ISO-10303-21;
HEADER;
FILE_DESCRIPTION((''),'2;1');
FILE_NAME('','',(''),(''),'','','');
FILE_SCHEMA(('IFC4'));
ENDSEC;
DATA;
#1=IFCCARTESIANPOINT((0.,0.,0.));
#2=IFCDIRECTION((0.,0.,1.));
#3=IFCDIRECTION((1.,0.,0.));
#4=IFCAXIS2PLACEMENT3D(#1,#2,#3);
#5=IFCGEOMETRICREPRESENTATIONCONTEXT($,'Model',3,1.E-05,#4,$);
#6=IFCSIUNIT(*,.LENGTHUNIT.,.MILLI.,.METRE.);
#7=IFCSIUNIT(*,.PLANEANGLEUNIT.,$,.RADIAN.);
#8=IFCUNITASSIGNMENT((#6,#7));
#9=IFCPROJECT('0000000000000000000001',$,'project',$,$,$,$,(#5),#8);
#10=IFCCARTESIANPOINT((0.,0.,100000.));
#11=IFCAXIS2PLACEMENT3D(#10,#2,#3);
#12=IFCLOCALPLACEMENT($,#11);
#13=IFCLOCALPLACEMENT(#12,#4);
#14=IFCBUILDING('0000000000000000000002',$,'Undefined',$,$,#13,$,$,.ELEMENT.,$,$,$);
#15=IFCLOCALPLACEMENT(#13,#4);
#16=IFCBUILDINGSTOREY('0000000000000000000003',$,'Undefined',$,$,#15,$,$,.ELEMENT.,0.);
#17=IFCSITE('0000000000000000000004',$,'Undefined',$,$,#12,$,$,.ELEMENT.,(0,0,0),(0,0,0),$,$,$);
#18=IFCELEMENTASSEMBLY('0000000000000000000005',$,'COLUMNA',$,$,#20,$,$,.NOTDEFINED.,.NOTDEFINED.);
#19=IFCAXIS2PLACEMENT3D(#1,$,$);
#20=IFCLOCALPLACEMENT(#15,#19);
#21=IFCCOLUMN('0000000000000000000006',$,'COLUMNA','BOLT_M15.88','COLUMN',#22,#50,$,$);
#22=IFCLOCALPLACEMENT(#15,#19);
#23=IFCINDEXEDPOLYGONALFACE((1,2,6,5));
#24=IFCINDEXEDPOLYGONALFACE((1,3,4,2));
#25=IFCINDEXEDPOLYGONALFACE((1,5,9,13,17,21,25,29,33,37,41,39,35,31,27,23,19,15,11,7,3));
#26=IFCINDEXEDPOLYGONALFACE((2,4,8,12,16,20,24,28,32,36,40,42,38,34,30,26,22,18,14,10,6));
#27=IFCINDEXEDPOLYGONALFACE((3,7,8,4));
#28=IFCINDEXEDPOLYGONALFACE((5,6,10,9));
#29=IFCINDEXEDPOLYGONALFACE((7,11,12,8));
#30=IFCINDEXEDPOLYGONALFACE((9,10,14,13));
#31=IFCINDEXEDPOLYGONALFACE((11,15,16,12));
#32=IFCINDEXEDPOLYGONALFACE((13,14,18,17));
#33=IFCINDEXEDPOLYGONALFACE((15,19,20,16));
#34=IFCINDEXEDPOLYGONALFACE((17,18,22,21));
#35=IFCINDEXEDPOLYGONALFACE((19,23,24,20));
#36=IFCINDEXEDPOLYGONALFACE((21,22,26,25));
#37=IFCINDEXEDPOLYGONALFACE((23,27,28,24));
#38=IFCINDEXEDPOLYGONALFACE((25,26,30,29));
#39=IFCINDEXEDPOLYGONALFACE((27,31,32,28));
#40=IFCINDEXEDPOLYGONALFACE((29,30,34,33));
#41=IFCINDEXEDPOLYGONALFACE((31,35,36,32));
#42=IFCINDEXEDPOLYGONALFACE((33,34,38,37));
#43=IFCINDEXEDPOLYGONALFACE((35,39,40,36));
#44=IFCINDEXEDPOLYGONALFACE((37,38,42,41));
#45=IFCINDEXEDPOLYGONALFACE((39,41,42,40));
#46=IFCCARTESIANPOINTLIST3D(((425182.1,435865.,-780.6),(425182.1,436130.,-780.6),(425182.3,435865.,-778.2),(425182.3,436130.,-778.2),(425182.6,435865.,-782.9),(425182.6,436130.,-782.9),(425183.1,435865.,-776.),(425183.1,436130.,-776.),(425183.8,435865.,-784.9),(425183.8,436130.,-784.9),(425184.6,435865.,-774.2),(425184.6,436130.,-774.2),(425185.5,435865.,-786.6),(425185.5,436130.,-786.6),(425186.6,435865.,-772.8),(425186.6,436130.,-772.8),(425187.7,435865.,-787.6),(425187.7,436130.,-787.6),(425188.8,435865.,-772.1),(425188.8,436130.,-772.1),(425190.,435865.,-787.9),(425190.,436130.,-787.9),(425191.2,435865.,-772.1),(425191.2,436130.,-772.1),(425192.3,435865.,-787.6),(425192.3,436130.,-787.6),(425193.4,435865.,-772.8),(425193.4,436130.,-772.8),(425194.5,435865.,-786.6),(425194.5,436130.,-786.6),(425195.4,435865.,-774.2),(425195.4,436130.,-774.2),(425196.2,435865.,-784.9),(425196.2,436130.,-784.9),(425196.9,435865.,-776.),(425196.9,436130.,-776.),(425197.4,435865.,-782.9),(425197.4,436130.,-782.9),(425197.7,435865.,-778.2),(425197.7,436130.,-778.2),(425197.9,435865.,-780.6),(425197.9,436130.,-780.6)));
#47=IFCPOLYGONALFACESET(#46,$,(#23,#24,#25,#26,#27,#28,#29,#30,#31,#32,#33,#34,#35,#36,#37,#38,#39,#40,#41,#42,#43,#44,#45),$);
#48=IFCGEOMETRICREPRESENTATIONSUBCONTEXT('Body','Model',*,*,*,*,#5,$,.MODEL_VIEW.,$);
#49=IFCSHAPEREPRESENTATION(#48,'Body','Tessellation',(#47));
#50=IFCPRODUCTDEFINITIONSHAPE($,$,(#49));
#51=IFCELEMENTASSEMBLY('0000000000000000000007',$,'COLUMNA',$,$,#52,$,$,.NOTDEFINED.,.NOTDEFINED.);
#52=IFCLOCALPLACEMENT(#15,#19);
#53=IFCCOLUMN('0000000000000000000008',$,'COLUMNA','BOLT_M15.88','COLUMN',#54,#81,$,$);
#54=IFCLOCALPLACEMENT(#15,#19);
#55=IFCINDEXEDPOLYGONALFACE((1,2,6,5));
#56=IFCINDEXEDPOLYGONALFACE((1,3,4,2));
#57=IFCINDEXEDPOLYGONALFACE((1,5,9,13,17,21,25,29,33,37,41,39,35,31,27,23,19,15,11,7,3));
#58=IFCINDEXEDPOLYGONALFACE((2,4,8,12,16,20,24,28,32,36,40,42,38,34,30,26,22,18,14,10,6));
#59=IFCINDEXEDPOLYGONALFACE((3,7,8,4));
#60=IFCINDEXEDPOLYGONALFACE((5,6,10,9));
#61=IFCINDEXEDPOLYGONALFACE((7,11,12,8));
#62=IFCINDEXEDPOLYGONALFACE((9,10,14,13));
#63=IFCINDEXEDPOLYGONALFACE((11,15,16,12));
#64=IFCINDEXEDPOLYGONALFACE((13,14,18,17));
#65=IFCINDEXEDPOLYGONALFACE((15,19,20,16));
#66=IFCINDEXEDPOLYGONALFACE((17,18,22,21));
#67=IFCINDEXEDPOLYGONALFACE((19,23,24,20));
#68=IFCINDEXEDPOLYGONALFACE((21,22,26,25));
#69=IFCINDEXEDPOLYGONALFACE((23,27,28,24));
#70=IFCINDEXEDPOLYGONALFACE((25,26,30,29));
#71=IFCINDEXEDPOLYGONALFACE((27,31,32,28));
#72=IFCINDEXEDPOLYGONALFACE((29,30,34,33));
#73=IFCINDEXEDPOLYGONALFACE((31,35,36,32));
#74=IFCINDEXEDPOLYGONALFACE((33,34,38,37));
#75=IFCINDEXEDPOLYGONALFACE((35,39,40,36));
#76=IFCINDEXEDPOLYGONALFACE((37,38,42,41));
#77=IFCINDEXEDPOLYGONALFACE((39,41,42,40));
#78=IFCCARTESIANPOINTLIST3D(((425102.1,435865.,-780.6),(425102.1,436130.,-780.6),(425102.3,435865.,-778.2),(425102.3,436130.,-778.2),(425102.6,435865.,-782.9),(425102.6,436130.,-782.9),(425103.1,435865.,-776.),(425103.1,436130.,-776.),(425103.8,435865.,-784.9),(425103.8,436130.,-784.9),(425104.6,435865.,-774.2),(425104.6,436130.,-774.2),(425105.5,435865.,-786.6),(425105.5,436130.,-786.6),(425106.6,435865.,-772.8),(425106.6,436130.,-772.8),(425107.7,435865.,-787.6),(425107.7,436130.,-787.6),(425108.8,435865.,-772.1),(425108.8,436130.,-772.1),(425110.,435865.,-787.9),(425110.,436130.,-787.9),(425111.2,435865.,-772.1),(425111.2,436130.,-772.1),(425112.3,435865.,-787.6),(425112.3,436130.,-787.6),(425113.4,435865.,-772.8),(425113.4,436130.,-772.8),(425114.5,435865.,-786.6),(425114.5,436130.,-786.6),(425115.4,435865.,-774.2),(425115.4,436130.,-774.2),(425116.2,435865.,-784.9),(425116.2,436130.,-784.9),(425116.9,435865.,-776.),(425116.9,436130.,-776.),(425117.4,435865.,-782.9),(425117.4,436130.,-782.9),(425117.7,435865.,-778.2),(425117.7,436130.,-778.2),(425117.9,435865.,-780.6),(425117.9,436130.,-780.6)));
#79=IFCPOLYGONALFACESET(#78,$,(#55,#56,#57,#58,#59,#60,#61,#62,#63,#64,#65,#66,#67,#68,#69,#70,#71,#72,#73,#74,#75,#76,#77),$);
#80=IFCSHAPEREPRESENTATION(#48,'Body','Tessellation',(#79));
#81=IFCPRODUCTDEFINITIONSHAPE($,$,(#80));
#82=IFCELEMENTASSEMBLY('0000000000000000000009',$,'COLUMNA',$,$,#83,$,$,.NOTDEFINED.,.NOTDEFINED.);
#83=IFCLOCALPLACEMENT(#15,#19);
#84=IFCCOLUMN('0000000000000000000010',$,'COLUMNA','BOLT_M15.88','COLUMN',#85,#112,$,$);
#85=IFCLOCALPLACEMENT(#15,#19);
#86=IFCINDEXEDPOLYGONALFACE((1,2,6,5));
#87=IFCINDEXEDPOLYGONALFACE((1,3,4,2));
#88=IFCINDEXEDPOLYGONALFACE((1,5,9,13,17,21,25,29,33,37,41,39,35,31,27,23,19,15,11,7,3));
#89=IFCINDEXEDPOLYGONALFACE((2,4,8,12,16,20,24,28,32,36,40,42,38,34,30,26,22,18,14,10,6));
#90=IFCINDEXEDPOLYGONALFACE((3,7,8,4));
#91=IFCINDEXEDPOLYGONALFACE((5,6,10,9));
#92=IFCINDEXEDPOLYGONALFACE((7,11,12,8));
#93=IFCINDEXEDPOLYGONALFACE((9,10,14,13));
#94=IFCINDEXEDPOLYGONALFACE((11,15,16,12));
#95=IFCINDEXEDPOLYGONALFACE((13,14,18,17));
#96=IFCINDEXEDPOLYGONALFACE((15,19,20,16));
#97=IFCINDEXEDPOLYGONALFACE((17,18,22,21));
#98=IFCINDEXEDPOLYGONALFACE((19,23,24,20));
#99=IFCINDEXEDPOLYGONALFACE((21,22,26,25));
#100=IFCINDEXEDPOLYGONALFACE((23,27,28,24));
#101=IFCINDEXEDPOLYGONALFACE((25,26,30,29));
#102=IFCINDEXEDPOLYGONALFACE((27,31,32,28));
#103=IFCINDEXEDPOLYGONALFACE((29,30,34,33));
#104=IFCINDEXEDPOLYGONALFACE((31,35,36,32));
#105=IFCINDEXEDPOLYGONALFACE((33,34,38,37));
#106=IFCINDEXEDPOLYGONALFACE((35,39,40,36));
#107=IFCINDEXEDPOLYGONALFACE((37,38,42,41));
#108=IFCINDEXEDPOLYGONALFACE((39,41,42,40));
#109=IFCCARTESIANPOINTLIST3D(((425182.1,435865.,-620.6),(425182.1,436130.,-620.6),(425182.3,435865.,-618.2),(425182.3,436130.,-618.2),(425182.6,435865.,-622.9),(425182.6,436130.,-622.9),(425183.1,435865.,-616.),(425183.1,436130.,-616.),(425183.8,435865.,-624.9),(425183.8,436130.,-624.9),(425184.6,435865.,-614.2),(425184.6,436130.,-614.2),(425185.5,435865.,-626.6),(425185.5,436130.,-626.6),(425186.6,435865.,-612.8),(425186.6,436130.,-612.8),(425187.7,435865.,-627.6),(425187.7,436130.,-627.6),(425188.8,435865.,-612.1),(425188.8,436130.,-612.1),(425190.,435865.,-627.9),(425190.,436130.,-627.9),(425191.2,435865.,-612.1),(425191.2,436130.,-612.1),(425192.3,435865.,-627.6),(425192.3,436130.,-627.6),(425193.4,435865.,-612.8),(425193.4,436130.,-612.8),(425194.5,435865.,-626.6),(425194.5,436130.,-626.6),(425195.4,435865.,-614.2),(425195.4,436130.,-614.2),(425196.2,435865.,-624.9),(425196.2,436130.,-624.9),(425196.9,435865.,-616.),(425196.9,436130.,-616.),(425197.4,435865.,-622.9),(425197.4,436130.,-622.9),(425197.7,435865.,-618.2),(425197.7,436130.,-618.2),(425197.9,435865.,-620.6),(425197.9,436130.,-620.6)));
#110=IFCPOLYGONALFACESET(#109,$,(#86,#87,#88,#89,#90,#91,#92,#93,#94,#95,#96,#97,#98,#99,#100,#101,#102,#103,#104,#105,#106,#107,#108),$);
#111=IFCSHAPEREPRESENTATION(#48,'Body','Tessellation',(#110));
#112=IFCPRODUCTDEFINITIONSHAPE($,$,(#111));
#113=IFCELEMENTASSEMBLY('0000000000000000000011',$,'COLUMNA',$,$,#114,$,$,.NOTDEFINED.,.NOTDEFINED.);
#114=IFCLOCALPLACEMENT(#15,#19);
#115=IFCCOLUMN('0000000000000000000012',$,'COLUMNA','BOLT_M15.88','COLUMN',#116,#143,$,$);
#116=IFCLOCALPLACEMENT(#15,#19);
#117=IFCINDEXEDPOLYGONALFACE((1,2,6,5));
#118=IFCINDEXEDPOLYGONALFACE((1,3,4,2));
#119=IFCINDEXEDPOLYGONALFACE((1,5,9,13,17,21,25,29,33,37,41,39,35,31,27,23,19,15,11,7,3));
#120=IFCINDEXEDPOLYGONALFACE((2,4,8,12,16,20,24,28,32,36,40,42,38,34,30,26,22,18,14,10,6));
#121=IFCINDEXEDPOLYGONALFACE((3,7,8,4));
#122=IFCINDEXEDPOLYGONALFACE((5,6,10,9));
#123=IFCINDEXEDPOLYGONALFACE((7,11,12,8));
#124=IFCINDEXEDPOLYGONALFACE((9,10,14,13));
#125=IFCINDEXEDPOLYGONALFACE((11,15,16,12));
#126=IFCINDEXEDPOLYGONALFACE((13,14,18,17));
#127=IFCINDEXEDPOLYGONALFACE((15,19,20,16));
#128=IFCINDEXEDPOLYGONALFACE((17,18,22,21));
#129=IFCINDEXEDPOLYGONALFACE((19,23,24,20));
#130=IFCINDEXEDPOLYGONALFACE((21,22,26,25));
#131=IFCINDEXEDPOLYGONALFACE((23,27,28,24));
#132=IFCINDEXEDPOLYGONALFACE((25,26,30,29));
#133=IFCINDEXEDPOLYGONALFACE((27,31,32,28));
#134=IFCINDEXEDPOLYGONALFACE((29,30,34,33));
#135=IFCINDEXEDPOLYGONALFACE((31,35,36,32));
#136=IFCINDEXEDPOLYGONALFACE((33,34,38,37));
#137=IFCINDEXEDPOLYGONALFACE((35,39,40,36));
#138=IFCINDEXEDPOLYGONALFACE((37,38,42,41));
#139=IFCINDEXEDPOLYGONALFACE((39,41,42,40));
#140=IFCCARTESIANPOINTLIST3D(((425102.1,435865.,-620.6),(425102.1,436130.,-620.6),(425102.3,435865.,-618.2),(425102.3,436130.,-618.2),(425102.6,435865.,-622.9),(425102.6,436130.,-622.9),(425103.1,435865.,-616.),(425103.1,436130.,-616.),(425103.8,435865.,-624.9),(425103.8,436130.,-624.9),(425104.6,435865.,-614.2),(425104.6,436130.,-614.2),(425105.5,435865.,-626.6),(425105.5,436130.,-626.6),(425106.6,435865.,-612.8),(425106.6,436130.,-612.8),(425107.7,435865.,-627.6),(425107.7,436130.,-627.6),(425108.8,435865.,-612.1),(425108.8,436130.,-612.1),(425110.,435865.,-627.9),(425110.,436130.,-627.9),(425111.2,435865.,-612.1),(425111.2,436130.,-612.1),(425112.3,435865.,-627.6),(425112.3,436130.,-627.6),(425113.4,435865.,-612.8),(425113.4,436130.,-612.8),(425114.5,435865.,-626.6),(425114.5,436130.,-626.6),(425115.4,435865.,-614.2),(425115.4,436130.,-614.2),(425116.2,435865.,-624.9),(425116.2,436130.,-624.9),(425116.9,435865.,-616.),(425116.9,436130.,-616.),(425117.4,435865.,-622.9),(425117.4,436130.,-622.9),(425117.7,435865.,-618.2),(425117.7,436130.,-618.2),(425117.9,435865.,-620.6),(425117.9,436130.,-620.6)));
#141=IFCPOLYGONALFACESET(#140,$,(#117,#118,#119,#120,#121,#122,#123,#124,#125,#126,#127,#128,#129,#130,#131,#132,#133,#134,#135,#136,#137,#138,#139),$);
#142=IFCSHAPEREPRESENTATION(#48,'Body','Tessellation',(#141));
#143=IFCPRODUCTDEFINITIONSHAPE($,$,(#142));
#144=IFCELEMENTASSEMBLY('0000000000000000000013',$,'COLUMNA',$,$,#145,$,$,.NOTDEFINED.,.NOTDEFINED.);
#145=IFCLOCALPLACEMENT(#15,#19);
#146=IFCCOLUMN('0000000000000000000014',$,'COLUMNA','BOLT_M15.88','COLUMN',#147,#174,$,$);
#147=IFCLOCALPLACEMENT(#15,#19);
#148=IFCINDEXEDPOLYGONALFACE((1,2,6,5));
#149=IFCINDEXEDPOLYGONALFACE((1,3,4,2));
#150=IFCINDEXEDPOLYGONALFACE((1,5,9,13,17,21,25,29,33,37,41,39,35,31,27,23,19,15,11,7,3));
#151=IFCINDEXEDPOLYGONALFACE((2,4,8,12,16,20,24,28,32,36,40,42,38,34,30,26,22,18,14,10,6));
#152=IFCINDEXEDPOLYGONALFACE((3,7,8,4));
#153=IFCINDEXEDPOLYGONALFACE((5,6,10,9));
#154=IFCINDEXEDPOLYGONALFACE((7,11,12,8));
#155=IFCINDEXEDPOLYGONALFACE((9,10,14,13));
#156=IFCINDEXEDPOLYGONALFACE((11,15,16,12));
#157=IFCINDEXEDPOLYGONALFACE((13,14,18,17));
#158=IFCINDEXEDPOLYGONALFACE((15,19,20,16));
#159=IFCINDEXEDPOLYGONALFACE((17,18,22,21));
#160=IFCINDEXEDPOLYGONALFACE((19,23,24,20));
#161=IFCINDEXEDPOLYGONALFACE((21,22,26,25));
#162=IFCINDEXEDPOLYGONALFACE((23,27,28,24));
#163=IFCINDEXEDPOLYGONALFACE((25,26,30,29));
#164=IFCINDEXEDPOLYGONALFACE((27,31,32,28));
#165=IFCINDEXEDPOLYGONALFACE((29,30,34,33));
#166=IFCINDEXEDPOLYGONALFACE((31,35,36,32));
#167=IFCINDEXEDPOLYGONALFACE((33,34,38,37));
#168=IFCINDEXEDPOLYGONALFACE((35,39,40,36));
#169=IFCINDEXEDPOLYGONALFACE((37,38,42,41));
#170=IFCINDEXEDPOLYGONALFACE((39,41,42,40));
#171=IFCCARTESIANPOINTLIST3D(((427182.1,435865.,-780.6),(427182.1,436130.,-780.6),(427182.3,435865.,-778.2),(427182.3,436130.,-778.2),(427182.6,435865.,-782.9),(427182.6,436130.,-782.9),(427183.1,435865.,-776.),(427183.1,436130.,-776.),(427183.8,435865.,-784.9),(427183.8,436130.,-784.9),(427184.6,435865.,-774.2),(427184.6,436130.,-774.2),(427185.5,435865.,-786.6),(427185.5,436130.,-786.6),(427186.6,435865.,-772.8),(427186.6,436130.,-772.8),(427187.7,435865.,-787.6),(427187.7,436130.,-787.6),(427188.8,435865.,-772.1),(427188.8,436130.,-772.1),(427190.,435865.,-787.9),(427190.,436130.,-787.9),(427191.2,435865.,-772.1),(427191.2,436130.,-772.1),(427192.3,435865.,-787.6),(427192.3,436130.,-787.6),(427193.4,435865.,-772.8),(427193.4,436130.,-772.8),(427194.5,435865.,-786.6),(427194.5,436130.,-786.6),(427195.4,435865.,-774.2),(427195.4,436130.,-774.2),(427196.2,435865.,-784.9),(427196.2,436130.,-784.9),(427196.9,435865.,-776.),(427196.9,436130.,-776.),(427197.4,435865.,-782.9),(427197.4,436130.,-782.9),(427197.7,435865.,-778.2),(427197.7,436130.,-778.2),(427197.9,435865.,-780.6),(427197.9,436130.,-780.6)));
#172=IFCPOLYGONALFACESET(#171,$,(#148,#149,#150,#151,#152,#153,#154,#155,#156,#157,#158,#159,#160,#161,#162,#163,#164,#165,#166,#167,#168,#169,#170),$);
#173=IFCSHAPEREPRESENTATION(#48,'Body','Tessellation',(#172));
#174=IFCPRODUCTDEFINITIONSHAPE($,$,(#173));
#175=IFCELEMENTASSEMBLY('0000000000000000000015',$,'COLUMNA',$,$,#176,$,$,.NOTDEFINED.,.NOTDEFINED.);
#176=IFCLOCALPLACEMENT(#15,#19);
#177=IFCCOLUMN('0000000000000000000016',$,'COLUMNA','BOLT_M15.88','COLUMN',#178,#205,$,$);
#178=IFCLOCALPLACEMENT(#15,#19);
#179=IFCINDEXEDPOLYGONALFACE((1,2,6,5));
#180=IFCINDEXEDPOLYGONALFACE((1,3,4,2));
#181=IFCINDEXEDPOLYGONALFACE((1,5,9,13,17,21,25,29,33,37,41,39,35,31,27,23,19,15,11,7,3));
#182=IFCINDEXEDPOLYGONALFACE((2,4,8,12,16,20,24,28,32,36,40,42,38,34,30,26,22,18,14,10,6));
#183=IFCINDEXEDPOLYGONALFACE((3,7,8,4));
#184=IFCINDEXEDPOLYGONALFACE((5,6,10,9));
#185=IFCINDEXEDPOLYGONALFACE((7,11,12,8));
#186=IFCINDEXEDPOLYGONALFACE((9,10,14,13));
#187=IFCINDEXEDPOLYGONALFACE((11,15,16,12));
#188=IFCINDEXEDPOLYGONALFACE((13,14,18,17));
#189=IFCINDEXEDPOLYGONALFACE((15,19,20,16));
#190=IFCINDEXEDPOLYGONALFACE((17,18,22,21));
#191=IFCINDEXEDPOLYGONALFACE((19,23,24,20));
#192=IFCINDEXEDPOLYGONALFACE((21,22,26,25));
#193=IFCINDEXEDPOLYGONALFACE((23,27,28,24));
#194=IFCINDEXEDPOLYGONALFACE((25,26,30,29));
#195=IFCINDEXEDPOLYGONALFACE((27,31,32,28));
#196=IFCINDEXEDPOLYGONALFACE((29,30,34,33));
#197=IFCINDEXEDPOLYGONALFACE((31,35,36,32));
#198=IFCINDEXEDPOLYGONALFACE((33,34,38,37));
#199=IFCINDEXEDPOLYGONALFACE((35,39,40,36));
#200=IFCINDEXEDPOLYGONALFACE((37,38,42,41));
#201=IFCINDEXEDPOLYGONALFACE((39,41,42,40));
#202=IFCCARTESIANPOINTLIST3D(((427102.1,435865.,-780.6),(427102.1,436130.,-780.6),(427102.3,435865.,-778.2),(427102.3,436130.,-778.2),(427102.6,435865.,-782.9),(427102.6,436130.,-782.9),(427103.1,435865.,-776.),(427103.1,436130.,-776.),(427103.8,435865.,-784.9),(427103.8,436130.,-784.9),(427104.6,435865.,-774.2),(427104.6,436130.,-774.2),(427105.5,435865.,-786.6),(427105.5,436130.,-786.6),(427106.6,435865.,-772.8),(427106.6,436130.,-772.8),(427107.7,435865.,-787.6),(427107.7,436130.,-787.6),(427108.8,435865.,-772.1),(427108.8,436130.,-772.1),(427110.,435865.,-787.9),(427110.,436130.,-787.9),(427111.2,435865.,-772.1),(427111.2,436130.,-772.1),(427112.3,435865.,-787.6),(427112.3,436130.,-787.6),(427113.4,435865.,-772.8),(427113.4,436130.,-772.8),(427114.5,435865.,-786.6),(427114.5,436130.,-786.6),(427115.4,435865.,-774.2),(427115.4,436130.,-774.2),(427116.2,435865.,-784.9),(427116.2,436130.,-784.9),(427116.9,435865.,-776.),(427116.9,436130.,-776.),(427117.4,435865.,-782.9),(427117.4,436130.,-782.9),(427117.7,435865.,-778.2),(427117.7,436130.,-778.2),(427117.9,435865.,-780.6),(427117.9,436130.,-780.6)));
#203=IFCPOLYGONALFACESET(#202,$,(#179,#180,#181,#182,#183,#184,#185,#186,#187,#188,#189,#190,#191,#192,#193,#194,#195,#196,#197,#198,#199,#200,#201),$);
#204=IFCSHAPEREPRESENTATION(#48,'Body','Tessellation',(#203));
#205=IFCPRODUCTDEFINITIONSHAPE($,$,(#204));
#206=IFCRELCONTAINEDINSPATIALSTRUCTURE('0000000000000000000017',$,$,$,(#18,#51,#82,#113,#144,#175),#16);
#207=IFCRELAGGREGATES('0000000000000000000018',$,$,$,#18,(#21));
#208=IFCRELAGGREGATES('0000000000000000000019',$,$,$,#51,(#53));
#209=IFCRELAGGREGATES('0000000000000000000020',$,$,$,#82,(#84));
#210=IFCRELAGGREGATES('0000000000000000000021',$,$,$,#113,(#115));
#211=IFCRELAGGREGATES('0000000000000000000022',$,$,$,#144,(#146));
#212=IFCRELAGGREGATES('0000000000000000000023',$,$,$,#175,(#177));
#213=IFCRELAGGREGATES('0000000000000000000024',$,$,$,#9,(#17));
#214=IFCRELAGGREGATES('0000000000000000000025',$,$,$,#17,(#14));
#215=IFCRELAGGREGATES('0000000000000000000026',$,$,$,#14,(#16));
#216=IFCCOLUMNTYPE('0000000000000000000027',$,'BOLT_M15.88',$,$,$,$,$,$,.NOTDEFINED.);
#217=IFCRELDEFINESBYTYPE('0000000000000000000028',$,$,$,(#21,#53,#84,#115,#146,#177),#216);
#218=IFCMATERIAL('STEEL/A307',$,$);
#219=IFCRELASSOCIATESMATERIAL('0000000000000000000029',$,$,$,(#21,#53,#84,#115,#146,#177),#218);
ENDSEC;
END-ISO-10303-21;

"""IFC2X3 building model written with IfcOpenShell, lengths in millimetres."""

from ifc_helpers import new_model, si_unit, frame, origin_with_axes, origin_2d_with_axis, place, context, subcontext, project, spatial, circle, extrude, material, type_object, element, aggregate, save


model = new_model("IFC2X3")

# Units and contexts
model_context = context("Model", 3, precision=1e-05, world=origin_with_axes())
body_context = subcontext(model_context, "Body", "Model", "MODEL_VIEW")
ifc_project = project(units=[si_unit("LENGTHUNIT", "METRE", prefix="MILLI"), si_unit("PLANEANGLEUNIT", "RADIAN")], contexts=[model_context])

# Site, building, storey
site_placement = place(None, frame((0.0, 0.0, 100000.0), z_axis=(0.0, 0.0, 1.0), x_axis=(1.0, 0.0, 0.0)))
site = spatial("IfcSite", under=ifc_project, at=site_placement, Name="Undefined", CompositionType="ELEMENT", RefLatitude=(0, 0, 0), RefLongitude=(0, 0, 0))
building_placement = place(site_placement, origin_with_axes())
building = spatial("IfcBuilding", under=site, at=building_placement, Name="Undefined", CompositionType="ELEMENT")
storey_placement = place(building_placement, origin_with_axes())
storey = spatial("IfcBuildingStorey", under=building, at=storey_placement, Name="Undefined", CompositionType="ELEMENT", Elevation=0.0)

# Element assemblies, columns
ifc_material_1 = material(Name="STEEL/A307")
column_type_1 = type_object("IfcColumnType", Name="BOLT_M15.88", PredefinedType="NOTDEFINED")
assembly_1_placement = place(storey_placement, origin_with_axes())
assembly_1 = element("IfcElementAssembly", 1, at=assembly_1_placement, inside=storey, Name="COLUMNA", AssemblyPlace="NOTDEFINED", PredefinedType="NOTDEFINED")
column_1_placement = place(assembly_1_placement, frame((425190.0, 436130.0, -780.0), z_axis=(0.0, -1.0, -0.000003), x_axis=(-1.0, 0.0, 0.0)))
column_1 = element("IfcColumn", 2, at=column_1_placement, type_object=column_type_1, material=ifc_material_1, Name="COLUMNA", Description="BOLT_M15.88", ObjectType="COLUMN", context=body_context, shape_type="SweptSolid", body=[
    extrude(circle(Radius=7.9, at=origin_2d_with_axis()), frame((0.0, 0.0, 265.0), z_axis=(0.0, 0.0, -1.0), x_axis=(0.0, 1.0, 0.0)), (0.0, 0.0, 1.0), 265.0),
])
aggregate(assembly_1, [column_1])
assembly_2_placement = place(storey_placement, origin_with_axes())
assembly_2 = element("IfcElementAssembly", 3, at=assembly_2_placement, inside=storey, Name="COLUMNA", AssemblyPlace="NOTDEFINED", PredefinedType="NOTDEFINED")
column_2_placement = place(assembly_2_placement, frame((425110.0, 436130.0, -780.0), z_axis=(0.0, -1.0, -0.000003), x_axis=(-1.0, 0.0, 0.0)))
column_2 = element("IfcColumn", 4, at=column_2_placement, type_object=column_type_1, material=ifc_material_1, Name="COLUMNA", Description="BOLT_M15.88", ObjectType="COLUMN", context=body_context, shape_type="SweptSolid", body=[
    extrude(circle(Radius=7.9, at=origin_2d_with_axis()), frame((0.0, 0.0, 265.0), z_axis=(0.0, 0.0, -1.0), x_axis=(0.0, 1.0, 0.0)), (0.0, 0.0, 1.0), 265.0),
])
aggregate(assembly_2, [column_2])
assembly_3_placement = place(storey_placement, origin_with_axes())
assembly_3 = element("IfcElementAssembly", 5, at=assembly_3_placement, inside=storey, Name="COLUMNA", AssemblyPlace="NOTDEFINED", PredefinedType="NOTDEFINED")
column_3_placement = place(assembly_3_placement, frame((425190.0, 436130.0, -620.0), z_axis=(0.0, -1.0, -0.000003), x_axis=(-1.0, 0.0, 0.0)))
column_3 = element("IfcColumn", 6, at=column_3_placement, type_object=column_type_1, material=ifc_material_1, Name="COLUMNA", Description="BOLT_M15.88", ObjectType="COLUMN", context=body_context, shape_type="SweptSolid", body=[
    extrude(circle(Radius=7.9, at=origin_2d_with_axis()), frame((0.0, 0.0, 265.0), z_axis=(0.0, 0.0, -1.0), x_axis=(0.0, 1.0, 0.0)), (0.0, 0.0, 1.0), 265.0),
])
aggregate(assembly_3, [column_3])
assembly_4_placement = place(storey_placement, origin_with_axes())
assembly_4 = element("IfcElementAssembly", 7, at=assembly_4_placement, inside=storey, Name="COLUMNA", AssemblyPlace="NOTDEFINED", PredefinedType="NOTDEFINED")
column_4_placement = place(assembly_4_placement, frame((425110.0, 436130.0, -620.0), z_axis=(0.0, -1.0, -0.000003), x_axis=(-1.0, 0.0, 0.0)))
column_4 = element("IfcColumn", 8, at=column_4_placement, type_object=column_type_1, material=ifc_material_1, Name="COLUMNA", Description="BOLT_M15.88", ObjectType="COLUMN", context=body_context, shape_type="SweptSolid", body=[
    extrude(circle(Radius=7.9, at=origin_2d_with_axis()), frame((0.0, 0.0, 265.0), z_axis=(0.0, 0.0, -1.0), x_axis=(0.0, 1.0, 0.0)), (0.0, 0.0, 1.0), 265.0),
])
aggregate(assembly_4, [column_4])
assembly_5_placement = place(storey_placement, origin_with_axes())
assembly_5 = element("IfcElementAssembly", 9, at=assembly_5_placement, inside=storey, Name="COLUMNA", AssemblyPlace="NOTDEFINED", PredefinedType="NOTDEFINED")
column_5_placement = place(assembly_5_placement, frame((427190.0, 436130.0, -780.0), z_axis=(0.0, -1.0, -0.000003), x_axis=(-1.0, 0.0, 0.0)))
column_5 = element("IfcColumn", 10, at=column_5_placement, type_object=column_type_1, material=ifc_material_1, Name="COLUMNA", Description="BOLT_M15.88", ObjectType="COLUMN", context=body_context, shape_type="SweptSolid", body=[
    extrude(circle(Radius=7.9, at=origin_2d_with_axis()), frame((0.0, 0.0, 265.0), z_axis=(0.0, 0.0, -1.0), x_axis=(0.0, 1.0, 0.0)), (0.0, 0.0, 1.0), 265.0),
])
aggregate(assembly_5, [column_5])
assembly_6_placement = place(storey_placement, origin_with_axes())
assembly_6 = element("IfcElementAssembly", 11, at=assembly_6_placement, inside=storey, Name="COLUMNA", AssemblyPlace="NOTDEFINED", PredefinedType="NOTDEFINED")
column_6_placement = place(assembly_6_placement, frame((427110.0, 436130.0, -780.0), z_axis=(0.0, -1.0, -0.000003), x_axis=(-1.0, 0.0, 0.0)))
column_6 = element("IfcColumn", 12, at=column_6_placement, type_object=column_type_1, material=ifc_material_1, Name="COLUMNA", Description="BOLT_M15.88", ObjectType="COLUMN", context=body_context, shape_type="SweptSolid", body=[
    extrude(circle(Radius=7.9, at=origin_2d_with_axis()), frame((0.0, 0.0, 265.0), z_axis=(0.0, 0.0, -1.0), x_axis=(0.0, 1.0, 0.0)), (0.0, 0.0, 1.0), 265.0),
])
aggregate(assembly_6, [column_6])

save(model, "model.ifc")
